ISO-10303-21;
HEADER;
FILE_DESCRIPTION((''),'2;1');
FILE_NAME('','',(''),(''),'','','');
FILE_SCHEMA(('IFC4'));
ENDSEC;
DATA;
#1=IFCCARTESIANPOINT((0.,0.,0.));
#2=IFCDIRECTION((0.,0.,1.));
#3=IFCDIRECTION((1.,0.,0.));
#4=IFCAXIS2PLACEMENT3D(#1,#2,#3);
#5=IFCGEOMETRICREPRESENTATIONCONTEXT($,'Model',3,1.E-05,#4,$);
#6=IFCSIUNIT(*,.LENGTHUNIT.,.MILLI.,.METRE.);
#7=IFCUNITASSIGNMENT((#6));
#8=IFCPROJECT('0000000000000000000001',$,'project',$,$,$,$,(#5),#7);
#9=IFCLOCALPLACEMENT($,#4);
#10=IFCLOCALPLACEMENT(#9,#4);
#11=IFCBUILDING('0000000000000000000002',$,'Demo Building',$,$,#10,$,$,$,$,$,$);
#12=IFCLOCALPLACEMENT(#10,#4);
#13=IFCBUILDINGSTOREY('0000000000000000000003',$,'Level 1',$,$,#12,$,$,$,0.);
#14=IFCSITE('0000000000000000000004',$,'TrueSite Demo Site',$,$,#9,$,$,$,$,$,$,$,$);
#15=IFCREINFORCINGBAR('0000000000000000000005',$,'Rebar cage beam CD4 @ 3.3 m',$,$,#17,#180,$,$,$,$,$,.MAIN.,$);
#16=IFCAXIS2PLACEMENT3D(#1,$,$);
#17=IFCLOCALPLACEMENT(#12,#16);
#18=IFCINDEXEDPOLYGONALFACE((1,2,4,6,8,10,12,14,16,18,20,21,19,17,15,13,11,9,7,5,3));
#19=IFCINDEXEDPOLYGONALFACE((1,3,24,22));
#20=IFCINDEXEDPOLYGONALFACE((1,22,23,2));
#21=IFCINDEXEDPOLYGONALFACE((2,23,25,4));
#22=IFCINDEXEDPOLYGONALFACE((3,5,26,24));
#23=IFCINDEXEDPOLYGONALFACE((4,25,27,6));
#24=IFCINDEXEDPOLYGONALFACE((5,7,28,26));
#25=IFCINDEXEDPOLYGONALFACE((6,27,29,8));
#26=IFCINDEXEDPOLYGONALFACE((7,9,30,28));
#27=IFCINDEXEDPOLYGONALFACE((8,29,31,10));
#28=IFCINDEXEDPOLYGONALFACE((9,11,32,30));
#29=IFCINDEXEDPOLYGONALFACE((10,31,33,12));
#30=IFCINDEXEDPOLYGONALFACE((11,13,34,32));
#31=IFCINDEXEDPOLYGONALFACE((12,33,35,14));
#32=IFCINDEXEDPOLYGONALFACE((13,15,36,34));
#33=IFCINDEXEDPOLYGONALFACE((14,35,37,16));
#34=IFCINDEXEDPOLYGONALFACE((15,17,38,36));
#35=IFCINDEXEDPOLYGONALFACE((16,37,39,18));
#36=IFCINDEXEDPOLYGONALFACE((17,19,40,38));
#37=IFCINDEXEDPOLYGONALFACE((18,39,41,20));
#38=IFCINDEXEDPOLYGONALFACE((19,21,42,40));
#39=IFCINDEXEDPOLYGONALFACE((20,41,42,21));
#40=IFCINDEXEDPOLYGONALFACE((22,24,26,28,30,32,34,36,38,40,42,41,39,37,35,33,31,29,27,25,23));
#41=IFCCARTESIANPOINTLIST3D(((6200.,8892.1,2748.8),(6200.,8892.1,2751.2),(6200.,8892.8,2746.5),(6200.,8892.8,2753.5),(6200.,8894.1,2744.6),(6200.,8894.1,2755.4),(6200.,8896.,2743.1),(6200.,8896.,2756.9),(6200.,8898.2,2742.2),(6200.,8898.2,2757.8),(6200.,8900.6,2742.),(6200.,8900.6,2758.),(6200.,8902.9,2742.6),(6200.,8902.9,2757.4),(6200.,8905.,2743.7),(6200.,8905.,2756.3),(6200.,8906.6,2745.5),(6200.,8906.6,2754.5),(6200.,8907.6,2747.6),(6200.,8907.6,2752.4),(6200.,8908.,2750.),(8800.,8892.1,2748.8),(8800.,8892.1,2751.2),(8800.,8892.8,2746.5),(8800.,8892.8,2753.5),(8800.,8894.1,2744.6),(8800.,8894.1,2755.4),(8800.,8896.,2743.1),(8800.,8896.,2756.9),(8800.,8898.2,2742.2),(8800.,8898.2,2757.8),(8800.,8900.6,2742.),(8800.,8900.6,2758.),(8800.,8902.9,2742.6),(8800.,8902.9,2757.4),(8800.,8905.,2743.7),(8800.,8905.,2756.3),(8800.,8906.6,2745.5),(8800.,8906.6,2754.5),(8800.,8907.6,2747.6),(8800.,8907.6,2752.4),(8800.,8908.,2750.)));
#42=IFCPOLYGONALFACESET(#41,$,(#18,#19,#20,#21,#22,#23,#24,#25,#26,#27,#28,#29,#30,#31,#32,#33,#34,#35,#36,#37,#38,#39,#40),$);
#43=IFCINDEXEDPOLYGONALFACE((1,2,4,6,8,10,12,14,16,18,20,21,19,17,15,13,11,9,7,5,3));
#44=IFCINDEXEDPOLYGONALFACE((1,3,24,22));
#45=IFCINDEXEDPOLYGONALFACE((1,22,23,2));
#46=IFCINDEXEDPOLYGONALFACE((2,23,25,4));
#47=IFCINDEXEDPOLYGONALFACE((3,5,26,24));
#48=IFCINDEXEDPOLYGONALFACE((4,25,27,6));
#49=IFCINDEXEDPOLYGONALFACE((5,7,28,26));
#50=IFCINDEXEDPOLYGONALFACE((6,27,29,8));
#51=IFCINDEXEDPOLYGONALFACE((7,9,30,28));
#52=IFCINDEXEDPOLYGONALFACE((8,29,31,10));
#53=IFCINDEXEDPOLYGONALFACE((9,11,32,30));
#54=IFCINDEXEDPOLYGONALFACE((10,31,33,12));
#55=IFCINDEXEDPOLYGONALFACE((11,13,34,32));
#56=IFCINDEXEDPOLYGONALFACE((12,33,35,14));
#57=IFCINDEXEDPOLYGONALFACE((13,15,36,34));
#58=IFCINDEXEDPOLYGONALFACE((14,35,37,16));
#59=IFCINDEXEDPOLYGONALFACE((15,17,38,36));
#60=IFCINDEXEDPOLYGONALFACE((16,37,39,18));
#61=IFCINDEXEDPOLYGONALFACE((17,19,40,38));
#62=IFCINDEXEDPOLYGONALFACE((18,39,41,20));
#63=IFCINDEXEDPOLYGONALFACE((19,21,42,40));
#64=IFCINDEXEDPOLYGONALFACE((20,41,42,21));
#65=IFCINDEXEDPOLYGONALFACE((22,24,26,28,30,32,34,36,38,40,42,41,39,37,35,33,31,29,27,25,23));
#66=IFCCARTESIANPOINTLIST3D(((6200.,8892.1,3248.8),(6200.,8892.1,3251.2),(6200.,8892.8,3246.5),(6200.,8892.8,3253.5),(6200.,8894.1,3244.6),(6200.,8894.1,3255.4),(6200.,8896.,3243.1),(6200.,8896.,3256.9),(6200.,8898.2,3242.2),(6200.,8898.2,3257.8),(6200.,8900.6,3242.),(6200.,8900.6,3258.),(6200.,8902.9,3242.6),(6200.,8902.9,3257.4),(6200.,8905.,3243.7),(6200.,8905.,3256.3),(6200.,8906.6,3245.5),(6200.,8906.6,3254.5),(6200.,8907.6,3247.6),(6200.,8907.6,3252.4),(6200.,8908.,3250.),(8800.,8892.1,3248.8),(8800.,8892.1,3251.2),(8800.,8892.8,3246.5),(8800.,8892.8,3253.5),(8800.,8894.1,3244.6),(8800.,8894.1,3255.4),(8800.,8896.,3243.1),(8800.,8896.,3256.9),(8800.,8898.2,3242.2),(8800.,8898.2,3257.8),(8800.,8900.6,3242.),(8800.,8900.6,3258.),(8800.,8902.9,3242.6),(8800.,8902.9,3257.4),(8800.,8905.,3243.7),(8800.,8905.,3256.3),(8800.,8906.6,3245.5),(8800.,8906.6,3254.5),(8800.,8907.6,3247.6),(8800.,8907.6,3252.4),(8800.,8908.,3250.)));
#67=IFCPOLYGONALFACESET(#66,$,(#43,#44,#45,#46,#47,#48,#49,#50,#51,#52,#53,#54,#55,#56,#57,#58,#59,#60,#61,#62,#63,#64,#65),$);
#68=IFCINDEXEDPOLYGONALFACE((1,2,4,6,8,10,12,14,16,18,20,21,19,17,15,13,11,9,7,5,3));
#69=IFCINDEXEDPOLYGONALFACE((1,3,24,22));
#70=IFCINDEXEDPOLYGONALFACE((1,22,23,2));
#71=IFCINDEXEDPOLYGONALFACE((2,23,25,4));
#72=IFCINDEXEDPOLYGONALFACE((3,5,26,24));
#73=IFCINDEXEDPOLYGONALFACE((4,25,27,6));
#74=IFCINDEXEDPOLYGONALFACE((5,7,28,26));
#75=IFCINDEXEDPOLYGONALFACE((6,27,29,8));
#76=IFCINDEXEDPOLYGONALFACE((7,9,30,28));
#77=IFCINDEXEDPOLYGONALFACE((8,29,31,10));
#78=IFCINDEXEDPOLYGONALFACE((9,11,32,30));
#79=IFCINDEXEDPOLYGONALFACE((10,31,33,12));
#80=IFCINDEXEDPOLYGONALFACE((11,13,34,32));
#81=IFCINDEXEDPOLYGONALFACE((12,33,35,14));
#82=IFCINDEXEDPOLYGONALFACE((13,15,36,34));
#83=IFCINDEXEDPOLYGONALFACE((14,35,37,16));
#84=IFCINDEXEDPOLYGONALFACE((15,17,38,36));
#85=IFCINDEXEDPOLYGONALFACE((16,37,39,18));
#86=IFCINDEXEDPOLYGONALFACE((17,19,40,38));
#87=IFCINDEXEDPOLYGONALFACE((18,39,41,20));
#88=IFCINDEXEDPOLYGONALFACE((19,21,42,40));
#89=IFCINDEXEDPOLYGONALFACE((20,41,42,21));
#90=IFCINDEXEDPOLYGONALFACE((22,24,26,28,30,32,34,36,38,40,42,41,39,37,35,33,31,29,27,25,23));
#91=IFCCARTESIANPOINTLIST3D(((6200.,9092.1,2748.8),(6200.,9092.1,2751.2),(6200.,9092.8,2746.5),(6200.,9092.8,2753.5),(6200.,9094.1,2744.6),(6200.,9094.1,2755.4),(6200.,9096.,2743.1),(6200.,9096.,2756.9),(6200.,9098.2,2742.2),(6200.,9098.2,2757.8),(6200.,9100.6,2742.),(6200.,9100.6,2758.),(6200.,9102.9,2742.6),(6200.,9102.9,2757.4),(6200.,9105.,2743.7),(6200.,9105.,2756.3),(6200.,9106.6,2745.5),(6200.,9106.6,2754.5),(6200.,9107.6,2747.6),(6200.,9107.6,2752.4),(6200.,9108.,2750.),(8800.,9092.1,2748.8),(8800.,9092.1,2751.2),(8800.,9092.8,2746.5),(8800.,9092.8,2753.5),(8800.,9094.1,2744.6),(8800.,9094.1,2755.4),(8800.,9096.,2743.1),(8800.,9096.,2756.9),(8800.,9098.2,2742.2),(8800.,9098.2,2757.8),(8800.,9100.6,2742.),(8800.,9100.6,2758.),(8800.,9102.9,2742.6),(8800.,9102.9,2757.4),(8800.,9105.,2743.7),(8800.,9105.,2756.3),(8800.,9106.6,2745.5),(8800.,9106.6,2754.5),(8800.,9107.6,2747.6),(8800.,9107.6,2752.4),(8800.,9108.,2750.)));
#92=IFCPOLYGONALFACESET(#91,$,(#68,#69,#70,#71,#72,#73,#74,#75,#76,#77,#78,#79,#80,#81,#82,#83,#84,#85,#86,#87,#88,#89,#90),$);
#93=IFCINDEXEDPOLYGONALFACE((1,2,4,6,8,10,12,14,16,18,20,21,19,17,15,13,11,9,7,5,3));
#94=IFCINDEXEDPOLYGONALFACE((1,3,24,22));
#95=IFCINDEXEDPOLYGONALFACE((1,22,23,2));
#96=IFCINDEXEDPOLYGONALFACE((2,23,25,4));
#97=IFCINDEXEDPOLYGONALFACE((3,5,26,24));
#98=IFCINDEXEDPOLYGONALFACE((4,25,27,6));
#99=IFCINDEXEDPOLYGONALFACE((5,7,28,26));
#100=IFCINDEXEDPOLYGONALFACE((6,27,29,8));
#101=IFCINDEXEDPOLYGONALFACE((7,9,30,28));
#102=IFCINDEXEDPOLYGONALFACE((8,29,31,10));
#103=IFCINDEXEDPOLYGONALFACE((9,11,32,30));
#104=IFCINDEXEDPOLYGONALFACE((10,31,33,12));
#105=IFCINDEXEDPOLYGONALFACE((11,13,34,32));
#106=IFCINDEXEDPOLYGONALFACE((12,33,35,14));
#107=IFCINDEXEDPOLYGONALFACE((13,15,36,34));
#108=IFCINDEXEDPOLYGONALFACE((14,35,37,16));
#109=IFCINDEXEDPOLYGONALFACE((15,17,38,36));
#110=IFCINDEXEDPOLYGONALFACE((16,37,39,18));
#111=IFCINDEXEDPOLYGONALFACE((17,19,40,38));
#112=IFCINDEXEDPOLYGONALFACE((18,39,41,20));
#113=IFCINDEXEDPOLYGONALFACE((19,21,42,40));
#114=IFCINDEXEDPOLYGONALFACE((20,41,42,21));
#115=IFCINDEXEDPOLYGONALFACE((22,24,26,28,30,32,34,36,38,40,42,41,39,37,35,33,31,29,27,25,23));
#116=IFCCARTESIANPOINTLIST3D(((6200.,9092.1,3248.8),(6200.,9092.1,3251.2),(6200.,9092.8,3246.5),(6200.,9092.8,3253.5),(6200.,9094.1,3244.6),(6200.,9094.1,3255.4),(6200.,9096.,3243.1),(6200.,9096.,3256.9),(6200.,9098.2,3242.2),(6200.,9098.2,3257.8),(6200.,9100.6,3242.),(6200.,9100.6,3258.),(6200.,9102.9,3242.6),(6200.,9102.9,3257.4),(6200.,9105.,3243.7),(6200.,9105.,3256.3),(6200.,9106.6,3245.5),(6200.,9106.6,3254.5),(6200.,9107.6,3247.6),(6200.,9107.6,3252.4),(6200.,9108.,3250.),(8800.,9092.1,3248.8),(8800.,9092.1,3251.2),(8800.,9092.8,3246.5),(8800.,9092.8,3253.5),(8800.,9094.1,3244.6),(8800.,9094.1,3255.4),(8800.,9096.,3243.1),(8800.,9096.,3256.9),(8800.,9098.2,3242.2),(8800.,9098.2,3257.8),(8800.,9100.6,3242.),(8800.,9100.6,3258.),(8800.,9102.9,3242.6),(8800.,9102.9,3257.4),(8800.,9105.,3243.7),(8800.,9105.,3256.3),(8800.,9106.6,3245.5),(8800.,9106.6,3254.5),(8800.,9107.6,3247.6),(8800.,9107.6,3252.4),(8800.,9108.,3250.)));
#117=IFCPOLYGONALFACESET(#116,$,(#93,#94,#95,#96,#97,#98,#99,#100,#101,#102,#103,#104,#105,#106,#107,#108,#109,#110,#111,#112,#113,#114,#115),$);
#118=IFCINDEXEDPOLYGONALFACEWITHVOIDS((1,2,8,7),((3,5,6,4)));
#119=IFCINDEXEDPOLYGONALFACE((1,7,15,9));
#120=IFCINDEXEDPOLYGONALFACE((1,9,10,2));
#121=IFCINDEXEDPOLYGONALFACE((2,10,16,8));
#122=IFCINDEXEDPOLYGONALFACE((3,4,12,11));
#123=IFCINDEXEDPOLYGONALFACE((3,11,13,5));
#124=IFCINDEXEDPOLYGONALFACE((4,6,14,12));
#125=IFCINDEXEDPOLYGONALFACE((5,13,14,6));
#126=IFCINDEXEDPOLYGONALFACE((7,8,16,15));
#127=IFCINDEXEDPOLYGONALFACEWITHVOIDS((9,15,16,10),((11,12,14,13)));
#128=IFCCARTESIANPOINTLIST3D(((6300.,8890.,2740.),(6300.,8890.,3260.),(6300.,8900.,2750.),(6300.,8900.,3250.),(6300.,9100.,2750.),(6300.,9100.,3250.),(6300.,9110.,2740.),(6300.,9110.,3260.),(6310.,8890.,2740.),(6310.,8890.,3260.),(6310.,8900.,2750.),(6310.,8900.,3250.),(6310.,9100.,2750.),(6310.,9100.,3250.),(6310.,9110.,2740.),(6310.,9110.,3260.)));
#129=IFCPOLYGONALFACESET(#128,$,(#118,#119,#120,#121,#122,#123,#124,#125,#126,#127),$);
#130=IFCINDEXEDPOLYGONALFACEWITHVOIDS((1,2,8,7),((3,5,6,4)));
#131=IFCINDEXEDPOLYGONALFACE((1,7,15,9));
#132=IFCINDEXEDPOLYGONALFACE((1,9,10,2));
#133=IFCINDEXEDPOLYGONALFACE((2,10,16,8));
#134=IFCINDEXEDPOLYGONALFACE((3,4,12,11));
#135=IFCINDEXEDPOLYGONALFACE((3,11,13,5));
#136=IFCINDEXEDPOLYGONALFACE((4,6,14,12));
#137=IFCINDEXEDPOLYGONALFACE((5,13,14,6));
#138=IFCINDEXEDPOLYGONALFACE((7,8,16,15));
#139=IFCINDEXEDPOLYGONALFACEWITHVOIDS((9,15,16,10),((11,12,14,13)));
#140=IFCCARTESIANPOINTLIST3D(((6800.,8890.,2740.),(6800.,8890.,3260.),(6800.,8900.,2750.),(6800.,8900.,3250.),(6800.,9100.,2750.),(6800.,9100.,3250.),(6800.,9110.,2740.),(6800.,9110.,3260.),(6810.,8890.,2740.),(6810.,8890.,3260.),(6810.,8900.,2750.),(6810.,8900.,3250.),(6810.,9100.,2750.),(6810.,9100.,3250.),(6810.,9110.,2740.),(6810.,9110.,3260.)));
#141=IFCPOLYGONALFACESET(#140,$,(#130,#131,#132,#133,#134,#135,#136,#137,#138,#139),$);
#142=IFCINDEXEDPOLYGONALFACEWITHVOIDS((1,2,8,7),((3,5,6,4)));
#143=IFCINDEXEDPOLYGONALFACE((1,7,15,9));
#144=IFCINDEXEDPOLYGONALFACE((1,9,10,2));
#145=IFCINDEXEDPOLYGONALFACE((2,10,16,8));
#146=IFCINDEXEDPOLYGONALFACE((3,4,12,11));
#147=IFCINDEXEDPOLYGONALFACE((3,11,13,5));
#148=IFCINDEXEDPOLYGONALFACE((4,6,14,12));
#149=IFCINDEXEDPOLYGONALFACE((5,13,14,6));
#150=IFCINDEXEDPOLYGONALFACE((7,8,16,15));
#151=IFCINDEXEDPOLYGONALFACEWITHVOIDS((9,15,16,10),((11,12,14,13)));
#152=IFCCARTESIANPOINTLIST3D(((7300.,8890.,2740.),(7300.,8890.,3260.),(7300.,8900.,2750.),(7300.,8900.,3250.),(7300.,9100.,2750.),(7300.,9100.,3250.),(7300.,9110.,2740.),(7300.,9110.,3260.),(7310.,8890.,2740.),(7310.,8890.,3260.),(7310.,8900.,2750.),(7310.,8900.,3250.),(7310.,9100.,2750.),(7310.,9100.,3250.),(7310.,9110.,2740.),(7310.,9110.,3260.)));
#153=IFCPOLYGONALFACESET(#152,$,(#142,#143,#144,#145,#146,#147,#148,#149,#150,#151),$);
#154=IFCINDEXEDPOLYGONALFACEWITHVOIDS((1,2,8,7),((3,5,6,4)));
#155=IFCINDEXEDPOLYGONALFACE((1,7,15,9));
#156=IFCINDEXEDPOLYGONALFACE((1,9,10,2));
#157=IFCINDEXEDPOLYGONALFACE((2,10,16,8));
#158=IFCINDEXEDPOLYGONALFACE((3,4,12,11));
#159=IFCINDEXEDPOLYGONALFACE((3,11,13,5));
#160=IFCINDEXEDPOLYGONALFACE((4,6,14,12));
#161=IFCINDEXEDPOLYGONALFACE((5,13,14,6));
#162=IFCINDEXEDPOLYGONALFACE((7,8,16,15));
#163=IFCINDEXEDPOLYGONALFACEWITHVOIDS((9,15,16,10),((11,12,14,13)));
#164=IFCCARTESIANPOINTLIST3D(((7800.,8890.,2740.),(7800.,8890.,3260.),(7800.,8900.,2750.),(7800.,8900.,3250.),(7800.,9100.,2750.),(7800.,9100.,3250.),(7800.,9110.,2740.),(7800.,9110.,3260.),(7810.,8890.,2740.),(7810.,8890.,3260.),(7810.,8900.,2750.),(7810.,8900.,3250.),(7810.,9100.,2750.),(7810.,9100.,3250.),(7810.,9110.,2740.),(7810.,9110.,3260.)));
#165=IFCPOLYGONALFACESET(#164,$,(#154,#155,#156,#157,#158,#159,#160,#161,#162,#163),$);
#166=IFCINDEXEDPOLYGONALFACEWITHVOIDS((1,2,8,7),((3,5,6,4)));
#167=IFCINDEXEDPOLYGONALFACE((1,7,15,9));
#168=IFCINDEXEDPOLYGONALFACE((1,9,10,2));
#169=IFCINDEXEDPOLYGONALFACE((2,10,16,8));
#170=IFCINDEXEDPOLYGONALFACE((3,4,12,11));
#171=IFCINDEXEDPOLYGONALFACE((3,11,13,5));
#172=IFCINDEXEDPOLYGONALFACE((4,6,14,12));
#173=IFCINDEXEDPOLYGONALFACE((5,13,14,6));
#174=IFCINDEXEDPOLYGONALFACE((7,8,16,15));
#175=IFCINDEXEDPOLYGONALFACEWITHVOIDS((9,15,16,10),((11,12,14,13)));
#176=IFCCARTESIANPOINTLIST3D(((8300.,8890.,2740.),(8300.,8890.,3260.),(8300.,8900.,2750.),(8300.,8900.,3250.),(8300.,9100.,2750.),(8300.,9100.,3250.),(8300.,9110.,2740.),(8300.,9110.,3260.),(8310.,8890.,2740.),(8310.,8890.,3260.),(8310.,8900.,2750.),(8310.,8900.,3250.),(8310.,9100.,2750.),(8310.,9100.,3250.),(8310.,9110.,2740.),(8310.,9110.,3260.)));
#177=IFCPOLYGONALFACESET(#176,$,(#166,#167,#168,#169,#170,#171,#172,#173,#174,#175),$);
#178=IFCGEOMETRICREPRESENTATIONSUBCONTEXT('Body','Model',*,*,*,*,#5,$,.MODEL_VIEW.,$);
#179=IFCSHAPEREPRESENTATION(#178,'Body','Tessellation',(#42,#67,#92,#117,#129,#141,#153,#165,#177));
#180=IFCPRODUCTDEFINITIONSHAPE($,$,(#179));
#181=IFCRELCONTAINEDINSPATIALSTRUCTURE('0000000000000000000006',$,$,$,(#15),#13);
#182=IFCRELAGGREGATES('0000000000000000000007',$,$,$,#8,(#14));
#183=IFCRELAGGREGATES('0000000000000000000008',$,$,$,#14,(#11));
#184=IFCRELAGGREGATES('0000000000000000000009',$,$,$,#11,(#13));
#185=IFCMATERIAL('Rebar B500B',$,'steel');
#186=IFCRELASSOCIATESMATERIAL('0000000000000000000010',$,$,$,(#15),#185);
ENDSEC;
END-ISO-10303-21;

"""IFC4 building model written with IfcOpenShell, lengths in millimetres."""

from ifc_helpers import new_model, si_unit, frame, origin_with_axes, place, context, subcontext, project, spatial, hollow_rectangle, circle, extrude, material, element, save


model = new_model("IFC4")

# Units and contexts
model_context = context("Model", 3, precision=1e-05, world=origin_with_axes())
body_context = subcontext(model_context, "Body", "Model", "MODEL_VIEW")
ifc_project = project(units=[si_unit("LENGTHUNIT", "METRE", prefix="MILLI")], contexts=[model_context])

# Site, building, storey
site_placement = place(None, origin_with_axes())
site = spatial("IfcSite", under=ifc_project, at=site_placement, Name="TrueSite Demo Site")
building_placement = place(site_placement, origin_with_axes())
building = spatial("IfcBuilding", under=site, at=building_placement, Name="Demo Building")
storey_placement = place(building_placement, origin_with_axes())
storey = spatial("IfcBuildingStorey", under=building, at=storey_placement, Name="Level 1", Elevation=0.0)

# Reinforcing bar
ifc_material_1 = material(Name="Rebar B500B", Category="steel")
for number, where, z_axis, x_axis, name in (
    (1, (6200.0, 9000.0, 3000.0), (1.0, 0.0, 0.0), (0.0, 1.0, 0.0), "Rebar cage beam CD4 @ 3.3 m"),
):
    element("IfcReinforcingBar", number, at=place(storey_placement, frame(where, z_axis=z_axis, x_axis=x_axis)), inside=storey, material=ifc_material_1, Name=name, PredefinedType="MAIN", context=body_context, shape_type="SweptSolid", body=[
        extrude(circle(Radius=8.0), frame((-100.0, -250.0, 0.0)), (0.0, 0.0, 1.0), 2600.0),
        extrude(circle(Radius=8.0), frame((-100.0, 250.0, 0.0)), (0.0, 0.0, 1.0), 2600.0),
        extrude(circle(Radius=8.0), frame((100.0, -250.0, 0.0)), (0.0, 0.0, 1.0), 2600.0),
        extrude(circle(Radius=8.0), frame((100.0, 250.0, 0.0)), (0.0, 0.0, 1.0), 2600.0),
        extrude(hollow_rectangle(XDim=220.0, YDim=520.0, WallThickness=10.0), frame((0.0, 0.0, 100.0)), (0.0, 0.0, 1.0), 10.0),
        extrude(hollow_rectangle(XDim=220.0, YDim=520.0, WallThickness=10.0), frame((0.0, 0.0, 600.0)), (0.0, 0.0, 1.0), 10.0),
        extrude(hollow_rectangle(XDim=220.0, YDim=520.0, WallThickness=10.0), frame((0.0, 0.0, 1100.0)), (0.0, 0.0, 1.0), 10.0),
        extrude(hollow_rectangle(XDim=220.0, YDim=520.0, WallThickness=10.0), frame((0.0, 0.0, 1600.0)), (0.0, 0.0, 1.0), 10.0),
        extrude(hollow_rectangle(XDim=220.0, YDim=520.0, WallThickness=10.0), frame((0.0, 0.0, 2100.0)), (0.0, 0.0, 1.0), 10.0),
    ])

save(model, "model.ifc")
